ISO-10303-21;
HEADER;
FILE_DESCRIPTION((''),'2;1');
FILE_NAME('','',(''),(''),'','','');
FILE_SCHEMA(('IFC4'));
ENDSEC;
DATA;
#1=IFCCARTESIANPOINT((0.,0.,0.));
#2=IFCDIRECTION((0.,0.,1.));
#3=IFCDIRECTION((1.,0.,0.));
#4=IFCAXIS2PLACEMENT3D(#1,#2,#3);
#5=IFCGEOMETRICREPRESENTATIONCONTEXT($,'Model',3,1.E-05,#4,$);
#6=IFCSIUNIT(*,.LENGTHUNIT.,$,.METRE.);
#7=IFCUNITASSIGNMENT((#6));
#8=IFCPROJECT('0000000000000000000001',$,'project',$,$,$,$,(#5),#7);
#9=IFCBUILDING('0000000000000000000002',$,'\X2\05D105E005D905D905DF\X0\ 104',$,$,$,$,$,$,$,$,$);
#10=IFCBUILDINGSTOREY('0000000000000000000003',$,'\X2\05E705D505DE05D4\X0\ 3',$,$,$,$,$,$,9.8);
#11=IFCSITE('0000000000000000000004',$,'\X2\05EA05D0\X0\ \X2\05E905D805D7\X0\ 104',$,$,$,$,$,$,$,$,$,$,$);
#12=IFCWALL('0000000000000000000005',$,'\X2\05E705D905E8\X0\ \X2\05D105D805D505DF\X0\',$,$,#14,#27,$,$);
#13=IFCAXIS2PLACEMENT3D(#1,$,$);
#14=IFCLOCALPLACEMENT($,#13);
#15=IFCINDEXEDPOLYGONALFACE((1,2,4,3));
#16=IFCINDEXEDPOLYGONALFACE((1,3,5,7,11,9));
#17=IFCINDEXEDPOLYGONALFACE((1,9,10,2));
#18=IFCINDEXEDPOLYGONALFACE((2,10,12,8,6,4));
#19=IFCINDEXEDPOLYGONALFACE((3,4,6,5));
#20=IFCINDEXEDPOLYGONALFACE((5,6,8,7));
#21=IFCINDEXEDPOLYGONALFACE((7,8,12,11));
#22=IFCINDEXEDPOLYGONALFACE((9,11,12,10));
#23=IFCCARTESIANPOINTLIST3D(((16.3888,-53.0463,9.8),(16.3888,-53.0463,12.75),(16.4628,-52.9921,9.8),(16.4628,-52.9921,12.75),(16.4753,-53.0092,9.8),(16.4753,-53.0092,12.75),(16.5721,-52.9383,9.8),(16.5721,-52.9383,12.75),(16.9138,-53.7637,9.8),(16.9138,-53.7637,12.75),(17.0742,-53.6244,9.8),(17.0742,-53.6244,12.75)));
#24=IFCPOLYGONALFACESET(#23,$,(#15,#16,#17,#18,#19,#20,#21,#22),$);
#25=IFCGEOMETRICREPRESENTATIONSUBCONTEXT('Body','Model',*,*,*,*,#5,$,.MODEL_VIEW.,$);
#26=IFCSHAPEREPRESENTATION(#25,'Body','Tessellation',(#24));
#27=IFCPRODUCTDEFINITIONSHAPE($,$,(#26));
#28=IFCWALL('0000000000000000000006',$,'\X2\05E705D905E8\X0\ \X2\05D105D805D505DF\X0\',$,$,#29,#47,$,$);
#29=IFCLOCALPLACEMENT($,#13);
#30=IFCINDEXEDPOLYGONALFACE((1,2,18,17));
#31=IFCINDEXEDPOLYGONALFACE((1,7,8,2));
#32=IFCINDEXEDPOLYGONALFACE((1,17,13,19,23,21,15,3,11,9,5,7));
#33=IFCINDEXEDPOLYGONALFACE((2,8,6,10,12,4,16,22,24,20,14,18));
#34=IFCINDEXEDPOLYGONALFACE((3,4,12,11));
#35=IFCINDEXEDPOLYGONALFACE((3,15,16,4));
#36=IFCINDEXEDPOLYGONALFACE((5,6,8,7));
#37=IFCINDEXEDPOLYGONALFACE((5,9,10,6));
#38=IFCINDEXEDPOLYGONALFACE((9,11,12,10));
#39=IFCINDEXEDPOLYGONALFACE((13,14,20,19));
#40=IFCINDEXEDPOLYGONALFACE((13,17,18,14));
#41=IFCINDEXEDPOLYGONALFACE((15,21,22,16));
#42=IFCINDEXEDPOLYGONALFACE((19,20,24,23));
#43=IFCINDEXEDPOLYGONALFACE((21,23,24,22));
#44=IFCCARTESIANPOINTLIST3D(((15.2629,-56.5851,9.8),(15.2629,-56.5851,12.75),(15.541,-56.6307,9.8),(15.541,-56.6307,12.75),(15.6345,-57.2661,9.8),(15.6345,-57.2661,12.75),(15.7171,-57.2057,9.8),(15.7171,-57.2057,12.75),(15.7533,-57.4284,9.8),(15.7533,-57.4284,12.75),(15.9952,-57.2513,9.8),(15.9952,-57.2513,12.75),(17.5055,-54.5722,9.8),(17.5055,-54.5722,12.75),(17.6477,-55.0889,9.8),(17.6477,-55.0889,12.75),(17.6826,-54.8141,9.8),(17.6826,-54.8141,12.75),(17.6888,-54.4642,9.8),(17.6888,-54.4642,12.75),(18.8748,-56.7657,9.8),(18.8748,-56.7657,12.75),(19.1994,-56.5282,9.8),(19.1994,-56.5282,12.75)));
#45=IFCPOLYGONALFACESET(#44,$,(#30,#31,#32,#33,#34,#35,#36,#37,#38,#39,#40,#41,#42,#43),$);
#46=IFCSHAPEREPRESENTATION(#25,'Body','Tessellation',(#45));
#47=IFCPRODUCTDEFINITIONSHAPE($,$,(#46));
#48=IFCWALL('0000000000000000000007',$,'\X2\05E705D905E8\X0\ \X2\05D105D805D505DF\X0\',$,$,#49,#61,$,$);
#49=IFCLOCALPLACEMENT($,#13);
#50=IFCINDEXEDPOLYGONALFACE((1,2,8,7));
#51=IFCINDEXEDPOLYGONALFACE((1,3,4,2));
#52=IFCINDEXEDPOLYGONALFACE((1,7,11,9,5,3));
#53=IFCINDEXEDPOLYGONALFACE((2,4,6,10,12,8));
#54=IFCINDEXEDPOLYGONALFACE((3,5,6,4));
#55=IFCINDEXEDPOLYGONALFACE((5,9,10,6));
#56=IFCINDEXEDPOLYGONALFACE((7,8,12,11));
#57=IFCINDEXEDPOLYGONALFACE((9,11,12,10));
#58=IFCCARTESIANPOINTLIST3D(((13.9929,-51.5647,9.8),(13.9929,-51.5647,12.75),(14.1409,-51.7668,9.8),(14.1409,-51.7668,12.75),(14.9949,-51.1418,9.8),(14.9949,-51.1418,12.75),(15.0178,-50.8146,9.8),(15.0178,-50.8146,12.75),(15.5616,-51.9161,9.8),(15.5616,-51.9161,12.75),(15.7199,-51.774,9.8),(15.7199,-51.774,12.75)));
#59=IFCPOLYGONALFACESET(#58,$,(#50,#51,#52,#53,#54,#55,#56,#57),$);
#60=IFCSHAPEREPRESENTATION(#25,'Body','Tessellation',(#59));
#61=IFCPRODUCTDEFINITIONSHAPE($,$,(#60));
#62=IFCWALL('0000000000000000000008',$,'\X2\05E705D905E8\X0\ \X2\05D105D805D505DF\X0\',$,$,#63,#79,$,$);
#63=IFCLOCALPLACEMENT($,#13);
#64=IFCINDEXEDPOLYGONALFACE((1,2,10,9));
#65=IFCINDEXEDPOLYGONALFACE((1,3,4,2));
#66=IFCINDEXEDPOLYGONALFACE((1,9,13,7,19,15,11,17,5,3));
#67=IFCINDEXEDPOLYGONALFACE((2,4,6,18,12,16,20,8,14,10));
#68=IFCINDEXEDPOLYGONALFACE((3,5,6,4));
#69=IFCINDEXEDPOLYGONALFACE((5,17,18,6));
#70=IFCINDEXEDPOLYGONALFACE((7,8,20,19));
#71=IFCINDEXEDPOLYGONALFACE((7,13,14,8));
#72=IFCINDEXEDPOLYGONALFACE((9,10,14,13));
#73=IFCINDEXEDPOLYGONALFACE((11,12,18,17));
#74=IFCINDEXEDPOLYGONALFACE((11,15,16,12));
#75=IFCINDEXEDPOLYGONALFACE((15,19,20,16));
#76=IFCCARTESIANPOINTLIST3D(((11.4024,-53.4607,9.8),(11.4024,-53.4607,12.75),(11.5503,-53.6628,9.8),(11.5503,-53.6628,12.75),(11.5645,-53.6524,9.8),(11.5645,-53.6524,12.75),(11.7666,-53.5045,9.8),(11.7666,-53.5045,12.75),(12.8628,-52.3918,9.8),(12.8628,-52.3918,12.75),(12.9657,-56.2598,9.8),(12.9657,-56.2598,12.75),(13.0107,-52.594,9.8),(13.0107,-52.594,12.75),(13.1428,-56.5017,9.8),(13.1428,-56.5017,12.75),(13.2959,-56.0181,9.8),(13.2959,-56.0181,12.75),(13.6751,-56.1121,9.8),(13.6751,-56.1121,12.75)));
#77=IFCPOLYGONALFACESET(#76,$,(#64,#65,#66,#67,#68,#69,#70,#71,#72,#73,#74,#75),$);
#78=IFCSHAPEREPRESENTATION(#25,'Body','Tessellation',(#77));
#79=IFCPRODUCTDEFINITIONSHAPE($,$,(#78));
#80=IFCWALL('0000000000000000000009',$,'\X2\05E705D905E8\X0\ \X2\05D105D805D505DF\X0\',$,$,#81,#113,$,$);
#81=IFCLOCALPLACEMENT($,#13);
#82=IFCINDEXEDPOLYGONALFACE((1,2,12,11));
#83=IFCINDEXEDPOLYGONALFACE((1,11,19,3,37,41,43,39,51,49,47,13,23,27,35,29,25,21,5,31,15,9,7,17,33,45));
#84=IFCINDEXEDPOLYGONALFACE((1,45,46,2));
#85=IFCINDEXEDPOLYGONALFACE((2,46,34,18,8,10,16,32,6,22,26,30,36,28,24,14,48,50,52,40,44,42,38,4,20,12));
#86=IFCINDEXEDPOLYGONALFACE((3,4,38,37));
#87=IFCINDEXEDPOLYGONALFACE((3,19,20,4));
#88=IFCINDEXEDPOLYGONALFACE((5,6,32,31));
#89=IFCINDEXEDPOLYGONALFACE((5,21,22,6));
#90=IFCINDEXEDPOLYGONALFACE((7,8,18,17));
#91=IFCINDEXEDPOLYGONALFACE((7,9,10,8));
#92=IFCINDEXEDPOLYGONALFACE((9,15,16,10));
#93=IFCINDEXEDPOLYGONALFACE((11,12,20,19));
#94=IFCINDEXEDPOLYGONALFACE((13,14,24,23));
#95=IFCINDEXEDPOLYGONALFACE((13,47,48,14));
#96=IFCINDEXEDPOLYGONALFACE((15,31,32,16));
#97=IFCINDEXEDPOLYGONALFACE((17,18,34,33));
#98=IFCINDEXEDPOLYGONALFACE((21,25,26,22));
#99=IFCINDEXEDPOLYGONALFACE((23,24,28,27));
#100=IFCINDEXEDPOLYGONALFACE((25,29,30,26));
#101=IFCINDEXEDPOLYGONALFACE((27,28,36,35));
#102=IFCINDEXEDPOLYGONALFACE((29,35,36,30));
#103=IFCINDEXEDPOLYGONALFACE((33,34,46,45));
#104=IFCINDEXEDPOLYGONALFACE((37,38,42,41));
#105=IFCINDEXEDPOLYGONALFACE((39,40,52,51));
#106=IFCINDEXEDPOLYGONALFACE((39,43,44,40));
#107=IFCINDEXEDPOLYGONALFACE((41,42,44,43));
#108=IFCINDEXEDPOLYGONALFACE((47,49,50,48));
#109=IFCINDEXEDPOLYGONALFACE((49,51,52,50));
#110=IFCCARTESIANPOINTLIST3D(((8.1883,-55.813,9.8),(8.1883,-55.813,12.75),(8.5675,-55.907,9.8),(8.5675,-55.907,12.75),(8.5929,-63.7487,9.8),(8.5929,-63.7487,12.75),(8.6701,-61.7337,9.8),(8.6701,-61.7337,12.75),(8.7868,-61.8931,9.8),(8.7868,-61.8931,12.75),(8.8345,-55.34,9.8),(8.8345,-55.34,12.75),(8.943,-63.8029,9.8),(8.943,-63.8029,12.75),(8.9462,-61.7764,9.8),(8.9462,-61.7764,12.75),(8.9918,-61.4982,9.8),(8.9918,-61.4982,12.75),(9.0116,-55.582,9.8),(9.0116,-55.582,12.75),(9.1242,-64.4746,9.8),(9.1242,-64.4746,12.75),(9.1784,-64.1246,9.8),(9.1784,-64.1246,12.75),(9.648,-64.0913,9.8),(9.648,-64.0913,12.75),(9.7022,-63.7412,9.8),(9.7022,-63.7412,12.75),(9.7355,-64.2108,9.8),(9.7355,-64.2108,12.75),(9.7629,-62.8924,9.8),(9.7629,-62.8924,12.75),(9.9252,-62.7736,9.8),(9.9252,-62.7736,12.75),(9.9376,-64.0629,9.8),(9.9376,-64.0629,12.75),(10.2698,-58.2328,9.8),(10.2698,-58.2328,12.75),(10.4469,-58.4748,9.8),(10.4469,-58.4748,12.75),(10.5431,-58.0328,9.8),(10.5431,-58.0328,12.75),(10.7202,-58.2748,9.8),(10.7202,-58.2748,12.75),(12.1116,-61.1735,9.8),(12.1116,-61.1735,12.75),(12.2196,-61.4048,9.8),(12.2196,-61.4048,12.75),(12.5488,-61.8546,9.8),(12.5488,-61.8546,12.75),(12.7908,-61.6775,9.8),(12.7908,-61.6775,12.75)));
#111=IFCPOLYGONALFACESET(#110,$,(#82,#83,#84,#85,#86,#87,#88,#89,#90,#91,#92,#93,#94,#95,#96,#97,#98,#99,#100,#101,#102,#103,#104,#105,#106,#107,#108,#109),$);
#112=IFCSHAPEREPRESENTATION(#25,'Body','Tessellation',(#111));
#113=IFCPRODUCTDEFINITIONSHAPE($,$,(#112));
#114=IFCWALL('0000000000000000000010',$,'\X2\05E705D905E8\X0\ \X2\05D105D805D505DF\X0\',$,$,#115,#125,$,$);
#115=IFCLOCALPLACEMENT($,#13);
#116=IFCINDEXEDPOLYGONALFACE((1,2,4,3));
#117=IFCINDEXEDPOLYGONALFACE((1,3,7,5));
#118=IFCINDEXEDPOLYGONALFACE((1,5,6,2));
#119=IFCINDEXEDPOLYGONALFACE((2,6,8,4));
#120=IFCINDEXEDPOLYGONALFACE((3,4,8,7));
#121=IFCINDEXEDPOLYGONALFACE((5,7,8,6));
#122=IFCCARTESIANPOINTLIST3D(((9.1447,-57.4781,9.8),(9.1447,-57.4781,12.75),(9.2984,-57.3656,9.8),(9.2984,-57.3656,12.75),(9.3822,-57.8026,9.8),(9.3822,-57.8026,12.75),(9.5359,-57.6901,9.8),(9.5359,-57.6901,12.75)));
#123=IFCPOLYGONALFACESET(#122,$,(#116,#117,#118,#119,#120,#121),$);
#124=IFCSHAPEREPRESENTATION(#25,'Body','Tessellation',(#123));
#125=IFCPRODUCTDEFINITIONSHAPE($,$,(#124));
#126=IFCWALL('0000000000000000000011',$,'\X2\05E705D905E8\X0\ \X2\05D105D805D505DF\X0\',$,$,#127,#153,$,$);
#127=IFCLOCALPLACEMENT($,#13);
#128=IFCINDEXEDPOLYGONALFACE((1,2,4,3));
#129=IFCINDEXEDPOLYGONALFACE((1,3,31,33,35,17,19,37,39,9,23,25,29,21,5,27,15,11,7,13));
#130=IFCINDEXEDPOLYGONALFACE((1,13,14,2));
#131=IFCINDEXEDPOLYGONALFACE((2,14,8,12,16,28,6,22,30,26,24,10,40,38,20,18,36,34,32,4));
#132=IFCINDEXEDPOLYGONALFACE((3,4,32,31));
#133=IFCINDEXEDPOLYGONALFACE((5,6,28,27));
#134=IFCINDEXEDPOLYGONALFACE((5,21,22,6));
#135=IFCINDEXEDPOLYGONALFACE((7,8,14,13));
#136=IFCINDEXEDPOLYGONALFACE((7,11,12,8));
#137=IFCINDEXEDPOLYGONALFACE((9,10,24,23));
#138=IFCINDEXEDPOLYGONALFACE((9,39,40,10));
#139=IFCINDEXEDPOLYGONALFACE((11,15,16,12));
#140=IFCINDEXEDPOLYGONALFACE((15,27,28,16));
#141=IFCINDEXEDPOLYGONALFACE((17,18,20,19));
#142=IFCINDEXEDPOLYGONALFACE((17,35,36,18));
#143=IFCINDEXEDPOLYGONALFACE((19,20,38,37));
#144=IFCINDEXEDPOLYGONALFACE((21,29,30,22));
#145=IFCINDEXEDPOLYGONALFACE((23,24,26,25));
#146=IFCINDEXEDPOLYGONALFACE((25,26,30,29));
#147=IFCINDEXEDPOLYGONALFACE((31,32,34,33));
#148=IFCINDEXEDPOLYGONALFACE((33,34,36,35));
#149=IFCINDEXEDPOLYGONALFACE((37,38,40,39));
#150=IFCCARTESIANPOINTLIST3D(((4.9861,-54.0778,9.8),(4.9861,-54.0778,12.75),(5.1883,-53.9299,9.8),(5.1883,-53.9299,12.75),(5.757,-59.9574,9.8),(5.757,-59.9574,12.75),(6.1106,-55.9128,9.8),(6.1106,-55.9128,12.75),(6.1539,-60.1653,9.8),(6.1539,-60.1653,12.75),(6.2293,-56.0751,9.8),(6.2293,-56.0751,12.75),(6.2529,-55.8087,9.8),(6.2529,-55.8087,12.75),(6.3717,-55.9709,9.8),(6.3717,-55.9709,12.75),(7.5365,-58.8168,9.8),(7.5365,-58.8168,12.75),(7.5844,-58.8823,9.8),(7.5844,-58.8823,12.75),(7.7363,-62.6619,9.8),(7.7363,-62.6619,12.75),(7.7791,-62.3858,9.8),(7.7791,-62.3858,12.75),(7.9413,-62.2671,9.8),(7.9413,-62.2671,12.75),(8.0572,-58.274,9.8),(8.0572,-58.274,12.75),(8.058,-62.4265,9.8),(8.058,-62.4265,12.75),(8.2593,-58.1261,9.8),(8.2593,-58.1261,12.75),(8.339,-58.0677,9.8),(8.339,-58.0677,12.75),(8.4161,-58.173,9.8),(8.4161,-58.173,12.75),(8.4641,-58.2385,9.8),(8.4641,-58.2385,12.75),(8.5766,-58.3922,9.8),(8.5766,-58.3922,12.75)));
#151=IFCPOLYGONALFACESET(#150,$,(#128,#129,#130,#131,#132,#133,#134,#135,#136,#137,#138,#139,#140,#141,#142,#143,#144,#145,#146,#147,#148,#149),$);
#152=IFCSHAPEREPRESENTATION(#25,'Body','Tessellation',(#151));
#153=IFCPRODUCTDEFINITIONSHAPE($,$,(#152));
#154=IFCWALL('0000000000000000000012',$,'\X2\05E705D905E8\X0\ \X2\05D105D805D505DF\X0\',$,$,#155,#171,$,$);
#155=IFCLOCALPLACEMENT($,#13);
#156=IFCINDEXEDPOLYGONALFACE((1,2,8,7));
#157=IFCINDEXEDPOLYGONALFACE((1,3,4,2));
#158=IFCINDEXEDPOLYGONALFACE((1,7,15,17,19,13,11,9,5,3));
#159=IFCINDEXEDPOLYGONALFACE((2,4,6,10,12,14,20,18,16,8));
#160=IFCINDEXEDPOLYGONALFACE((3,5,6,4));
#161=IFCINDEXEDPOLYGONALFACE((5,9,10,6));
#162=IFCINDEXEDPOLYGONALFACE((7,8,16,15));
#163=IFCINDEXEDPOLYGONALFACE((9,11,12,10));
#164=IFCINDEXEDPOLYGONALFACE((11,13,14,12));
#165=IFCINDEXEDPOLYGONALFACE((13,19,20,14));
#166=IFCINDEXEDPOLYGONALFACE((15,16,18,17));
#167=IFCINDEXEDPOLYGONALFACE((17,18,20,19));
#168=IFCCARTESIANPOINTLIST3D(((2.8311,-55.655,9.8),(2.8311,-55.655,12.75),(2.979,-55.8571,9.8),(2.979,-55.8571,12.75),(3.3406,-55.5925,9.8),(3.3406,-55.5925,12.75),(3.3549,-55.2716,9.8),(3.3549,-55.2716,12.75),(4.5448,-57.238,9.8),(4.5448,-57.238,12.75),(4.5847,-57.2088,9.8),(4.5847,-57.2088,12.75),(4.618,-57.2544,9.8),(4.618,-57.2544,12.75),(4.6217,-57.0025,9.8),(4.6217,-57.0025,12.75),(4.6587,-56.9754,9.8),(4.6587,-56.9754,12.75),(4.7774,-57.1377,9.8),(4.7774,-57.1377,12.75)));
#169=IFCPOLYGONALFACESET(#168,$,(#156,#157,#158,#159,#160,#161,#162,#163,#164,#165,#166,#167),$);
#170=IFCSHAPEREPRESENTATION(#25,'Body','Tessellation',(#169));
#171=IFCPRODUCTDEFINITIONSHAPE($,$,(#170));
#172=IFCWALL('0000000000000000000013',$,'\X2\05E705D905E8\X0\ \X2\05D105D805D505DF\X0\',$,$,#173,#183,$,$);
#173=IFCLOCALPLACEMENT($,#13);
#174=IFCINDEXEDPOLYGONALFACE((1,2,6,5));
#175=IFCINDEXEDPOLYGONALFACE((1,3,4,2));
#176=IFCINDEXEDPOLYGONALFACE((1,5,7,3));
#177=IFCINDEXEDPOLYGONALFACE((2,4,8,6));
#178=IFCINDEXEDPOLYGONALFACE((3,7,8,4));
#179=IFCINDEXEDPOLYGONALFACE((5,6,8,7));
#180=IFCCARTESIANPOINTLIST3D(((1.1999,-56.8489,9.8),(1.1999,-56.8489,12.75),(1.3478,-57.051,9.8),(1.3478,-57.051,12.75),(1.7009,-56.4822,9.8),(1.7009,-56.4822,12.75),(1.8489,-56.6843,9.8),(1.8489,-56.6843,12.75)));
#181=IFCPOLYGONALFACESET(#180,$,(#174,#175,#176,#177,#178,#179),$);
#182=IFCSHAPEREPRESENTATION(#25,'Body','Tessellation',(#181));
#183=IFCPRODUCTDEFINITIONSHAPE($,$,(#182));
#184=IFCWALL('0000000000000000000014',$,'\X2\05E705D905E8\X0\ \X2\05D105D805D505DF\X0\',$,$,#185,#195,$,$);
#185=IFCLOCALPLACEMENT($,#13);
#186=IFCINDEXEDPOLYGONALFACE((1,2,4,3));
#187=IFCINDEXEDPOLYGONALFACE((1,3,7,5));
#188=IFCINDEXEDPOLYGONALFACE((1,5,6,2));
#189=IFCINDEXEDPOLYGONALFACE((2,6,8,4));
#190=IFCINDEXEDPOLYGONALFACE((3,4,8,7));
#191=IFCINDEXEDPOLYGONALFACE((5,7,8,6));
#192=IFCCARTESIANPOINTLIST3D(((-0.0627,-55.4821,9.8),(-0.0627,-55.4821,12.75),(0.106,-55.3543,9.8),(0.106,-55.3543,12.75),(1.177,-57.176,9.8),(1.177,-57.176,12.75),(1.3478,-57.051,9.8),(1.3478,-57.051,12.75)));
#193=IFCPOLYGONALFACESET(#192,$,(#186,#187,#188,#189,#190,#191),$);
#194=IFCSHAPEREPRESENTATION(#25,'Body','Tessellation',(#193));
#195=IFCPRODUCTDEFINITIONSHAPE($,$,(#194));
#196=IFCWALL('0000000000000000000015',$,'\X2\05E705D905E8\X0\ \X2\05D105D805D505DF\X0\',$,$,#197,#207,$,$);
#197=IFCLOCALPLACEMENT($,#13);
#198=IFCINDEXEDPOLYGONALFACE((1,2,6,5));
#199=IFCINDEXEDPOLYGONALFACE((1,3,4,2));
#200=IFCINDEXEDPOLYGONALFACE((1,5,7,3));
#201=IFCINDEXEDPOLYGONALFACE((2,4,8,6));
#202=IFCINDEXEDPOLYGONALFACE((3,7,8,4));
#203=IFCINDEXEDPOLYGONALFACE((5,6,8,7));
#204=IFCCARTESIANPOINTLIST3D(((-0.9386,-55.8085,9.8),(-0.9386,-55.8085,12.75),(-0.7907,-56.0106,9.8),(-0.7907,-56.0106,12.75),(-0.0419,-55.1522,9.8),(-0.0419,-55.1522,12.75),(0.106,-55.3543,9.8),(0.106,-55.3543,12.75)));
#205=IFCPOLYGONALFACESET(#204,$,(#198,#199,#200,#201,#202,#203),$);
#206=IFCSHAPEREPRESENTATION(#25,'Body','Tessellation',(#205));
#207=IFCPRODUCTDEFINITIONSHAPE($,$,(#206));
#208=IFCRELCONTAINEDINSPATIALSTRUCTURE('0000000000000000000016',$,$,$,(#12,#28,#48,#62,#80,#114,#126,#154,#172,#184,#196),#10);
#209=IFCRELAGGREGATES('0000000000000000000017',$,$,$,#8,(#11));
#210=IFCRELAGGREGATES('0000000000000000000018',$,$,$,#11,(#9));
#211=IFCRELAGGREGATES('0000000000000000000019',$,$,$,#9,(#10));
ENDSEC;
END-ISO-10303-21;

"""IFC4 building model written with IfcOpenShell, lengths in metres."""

from ifc_helpers import new_model, si_unit, frame, origin_with_axes, context, subcontext, project, spatial, polyline, outline, extrude, element, save


model = new_model("IFC4")

# Units and contexts
model_context = context("Model", 3, precision=1e-05, world=origin_with_axes())
body_context = subcontext(model_context, "Body", "Model", "MODEL_VIEW")
ifc_project = project(units=[si_unit("LENGTHUNIT", "METRE")], contexts=[model_context])

# Site, building, storey
site = spatial("IfcSite", under=ifc_project, Name="תא שטח 104")
building = spatial("IfcBuilding", under=site, Name="בניין 104")
storey = spatial("IfcBuildingStorey", under=building, Name="קומה 3", Elevation=9.8)

# Walls
element("IfcWall", 1, inside=storey, Name="קיר בטון", context=body_context, shape_type="SweptSolid", body=[
    extrude(outline(polyline([(16.4628, -52.9921), (16.3888, -53.0463), (16.9138, -53.7637), (17.0742, -53.6244), (16.5721, -52.9383), (16.4753, -53.0092), (16.4628, -52.9921)])), frame((0.0, 0.0, 9.8)), (0.0, 0.0, 1.0), 2.95),
])
element("IfcWall", 2, inside=storey, Name="קיר בטון", context=body_context, shape_type="SweptSolid", body=[
    extrude(outline(polyline([(17.6826, -54.8141), (15.2629, -56.5851), (15.7171, -57.2057), (15.6345, -57.2661), (15.7533, -57.4284), (15.9952, -57.2513), (15.541, -56.6307), (17.6477, -55.0889), (18.8748, -56.7657), (19.1994, -56.5282), (17.6888, -54.4642), (17.5055, -54.5722), (17.6826, -54.8141)])), frame((0.0, 0.0, 9.8)), (0.0, 0.0, 1.0), 2.95),
])
element("IfcWall", 3, inside=storey, Name="קיר בטון", context=body_context, shape_type="SweptSolid", body=[
    extrude(outline(polyline([(13.9929, -51.5647), (14.1409, -51.7668), (14.9949, -51.1418), (15.5616, -51.9161), (15.7199, -51.774), (15.0178, -50.8146), (13.9929, -51.5647)])), frame((0.0, 0.0, 9.8)), (0.0, 0.0, 1.0), 2.95),
])
element("IfcWall", 4, inside=storey, Name="קיר בטון", context=body_context, shape_type="SweptSolid", body=[
    extrude(outline(polyline([(12.9657, -56.2598), (13.1428, -56.5017), (13.6751, -56.1121), (11.7666, -53.5045), (13.0107, -52.594), (12.8628, -52.3918), (11.4024, -53.4607), (11.5503, -53.6628), (11.5645, -53.6524), (13.2959, -56.0181), (12.9657, -56.2598)])), frame((0.0, 0.0, 9.8)), (0.0, 0.0, 1.0), 2.95),
])
element("IfcWall", 5, inside=storey, Name="קיר בטון", context=body_context, shape_type="SweptSolid", body=[
    extrude(outline(polyline([(8.1883, -55.813), (12.1116, -61.1735), (9.9252, -62.7736), (8.9918, -61.4982), (8.6701, -61.7337), (8.7868, -61.8931), (8.9462, -61.7764), (9.7629, -62.8924), (8.5929, -63.7487), (9.1242, -64.4746), (9.648, -64.0913), (9.7355, -64.2108), (9.9376, -64.0629), (9.7022, -63.7412), (9.1784, -64.1246), (8.943, -63.8029), (12.2196, -61.4048), (12.5488, -61.8546), (12.7908, -61.6775), (10.4469, -58.4748), (10.7202, -58.2748), (10.5431, -58.0328), (10.2698, -58.2328), (8.5675, -55.907), (9.0116, -55.582), (8.8345, -55.34), (8.1883, -55.813)])), frame((0.0, 0.0, 9.8)), (0.0, 0.0, 1.0), 2.95),
])
element("IfcWall", 6, inside=storey, Name="קיר בטון", context=body_context, shape_type="SweptSolid", body=[
    extrude(outline(polyline([(9.5359, -57.6901), (9.2984, -57.3656), (9.1447, -57.4781), (9.3822, -57.8026), (9.5359, -57.6901)])), frame((0.0, 0.0, 9.8)), (0.0, 0.0, 1.0), 2.95),
])
element("IfcWall", 7, inside=storey, Name="קיר בטון", context=body_context, shape_type="SweptSolid", body=[
    extrude(outline(polyline([(8.4641, -58.2385), (7.5844, -58.8823), (7.5365, -58.8168), (8.4161, -58.173), (8.339, -58.0677), (8.2593, -58.1261), (5.1883, -53.9299), (4.9861, -54.0778), (6.2529, -55.8087), (6.1106, -55.9128), (6.2293, -56.0751), (6.3717, -55.9709), (8.0572, -58.274), (5.757, -59.9574), (7.7363, -62.6619), (8.058, -62.4265), (7.9413, -62.2671), (7.7791, -62.3858), (6.1539, -60.1653), (8.5766, -58.3922), (8.4641, -58.2385)])), frame((0.0, 0.0, 9.8)), (0.0, 0.0, 1.0), 2.95),
])
element("IfcWall", 8, inside=storey, Name="קיר בטון", context=body_context, shape_type="SweptSolid", body=[
    extrude(outline(polyline([(2.8311, -55.655), (2.979, -55.8571), (3.3406, -55.5925), (4.5448, -57.238), (4.5847, -57.2088), (4.618, -57.2544), (4.7774, -57.1377), (4.6587, -56.9754), (4.6217, -57.0025), (3.3549, -55.2716), (2.8311, -55.655)])), frame((0.0, 0.0, 9.8)), (0.0, 0.0, 1.0), 2.95),
])
element("IfcWall", 9, inside=storey, Name="קיר בטון", context=body_context, shape_type="SweptSolid", body=[
    extrude(outline(polyline([(1.8489, -56.6843), (1.7009, -56.4822), (1.1999, -56.8489), (1.3478, -57.051), (1.8489, -56.6843)])), frame((0.0, 0.0, 9.8)), (0.0, 0.0, 1.0), 2.95),
])
element("IfcWall", 10, inside=storey, Name="קיר בטון", context=body_context, shape_type="SweptSolid", body=[
    extrude(outline(polyline([(-0.0627, -55.4821), (1.177, -57.176), (1.3478, -57.051), (0.106, -55.3543), (-0.0627, -55.4821)])), frame((0.0, 0.0, 9.8)), (0.0, 0.0, 1.0), 2.95),
])
element("IfcWall", 11, inside=storey, Name="קיר בטון", context=body_context, shape_type="SweptSolid", body=[
    extrude(outline(polyline([(-0.7907, -56.0106), (0.106, -55.3543), (0.106, -55.3543), (-0.0419, -55.1522), (-0.9386, -55.8085), (-0.7907, -56.0106)])), frame((0.0, 0.0, 9.8)), (0.0, 0.0, 1.0), 2.95),
])

save(model, "model.ifc")
